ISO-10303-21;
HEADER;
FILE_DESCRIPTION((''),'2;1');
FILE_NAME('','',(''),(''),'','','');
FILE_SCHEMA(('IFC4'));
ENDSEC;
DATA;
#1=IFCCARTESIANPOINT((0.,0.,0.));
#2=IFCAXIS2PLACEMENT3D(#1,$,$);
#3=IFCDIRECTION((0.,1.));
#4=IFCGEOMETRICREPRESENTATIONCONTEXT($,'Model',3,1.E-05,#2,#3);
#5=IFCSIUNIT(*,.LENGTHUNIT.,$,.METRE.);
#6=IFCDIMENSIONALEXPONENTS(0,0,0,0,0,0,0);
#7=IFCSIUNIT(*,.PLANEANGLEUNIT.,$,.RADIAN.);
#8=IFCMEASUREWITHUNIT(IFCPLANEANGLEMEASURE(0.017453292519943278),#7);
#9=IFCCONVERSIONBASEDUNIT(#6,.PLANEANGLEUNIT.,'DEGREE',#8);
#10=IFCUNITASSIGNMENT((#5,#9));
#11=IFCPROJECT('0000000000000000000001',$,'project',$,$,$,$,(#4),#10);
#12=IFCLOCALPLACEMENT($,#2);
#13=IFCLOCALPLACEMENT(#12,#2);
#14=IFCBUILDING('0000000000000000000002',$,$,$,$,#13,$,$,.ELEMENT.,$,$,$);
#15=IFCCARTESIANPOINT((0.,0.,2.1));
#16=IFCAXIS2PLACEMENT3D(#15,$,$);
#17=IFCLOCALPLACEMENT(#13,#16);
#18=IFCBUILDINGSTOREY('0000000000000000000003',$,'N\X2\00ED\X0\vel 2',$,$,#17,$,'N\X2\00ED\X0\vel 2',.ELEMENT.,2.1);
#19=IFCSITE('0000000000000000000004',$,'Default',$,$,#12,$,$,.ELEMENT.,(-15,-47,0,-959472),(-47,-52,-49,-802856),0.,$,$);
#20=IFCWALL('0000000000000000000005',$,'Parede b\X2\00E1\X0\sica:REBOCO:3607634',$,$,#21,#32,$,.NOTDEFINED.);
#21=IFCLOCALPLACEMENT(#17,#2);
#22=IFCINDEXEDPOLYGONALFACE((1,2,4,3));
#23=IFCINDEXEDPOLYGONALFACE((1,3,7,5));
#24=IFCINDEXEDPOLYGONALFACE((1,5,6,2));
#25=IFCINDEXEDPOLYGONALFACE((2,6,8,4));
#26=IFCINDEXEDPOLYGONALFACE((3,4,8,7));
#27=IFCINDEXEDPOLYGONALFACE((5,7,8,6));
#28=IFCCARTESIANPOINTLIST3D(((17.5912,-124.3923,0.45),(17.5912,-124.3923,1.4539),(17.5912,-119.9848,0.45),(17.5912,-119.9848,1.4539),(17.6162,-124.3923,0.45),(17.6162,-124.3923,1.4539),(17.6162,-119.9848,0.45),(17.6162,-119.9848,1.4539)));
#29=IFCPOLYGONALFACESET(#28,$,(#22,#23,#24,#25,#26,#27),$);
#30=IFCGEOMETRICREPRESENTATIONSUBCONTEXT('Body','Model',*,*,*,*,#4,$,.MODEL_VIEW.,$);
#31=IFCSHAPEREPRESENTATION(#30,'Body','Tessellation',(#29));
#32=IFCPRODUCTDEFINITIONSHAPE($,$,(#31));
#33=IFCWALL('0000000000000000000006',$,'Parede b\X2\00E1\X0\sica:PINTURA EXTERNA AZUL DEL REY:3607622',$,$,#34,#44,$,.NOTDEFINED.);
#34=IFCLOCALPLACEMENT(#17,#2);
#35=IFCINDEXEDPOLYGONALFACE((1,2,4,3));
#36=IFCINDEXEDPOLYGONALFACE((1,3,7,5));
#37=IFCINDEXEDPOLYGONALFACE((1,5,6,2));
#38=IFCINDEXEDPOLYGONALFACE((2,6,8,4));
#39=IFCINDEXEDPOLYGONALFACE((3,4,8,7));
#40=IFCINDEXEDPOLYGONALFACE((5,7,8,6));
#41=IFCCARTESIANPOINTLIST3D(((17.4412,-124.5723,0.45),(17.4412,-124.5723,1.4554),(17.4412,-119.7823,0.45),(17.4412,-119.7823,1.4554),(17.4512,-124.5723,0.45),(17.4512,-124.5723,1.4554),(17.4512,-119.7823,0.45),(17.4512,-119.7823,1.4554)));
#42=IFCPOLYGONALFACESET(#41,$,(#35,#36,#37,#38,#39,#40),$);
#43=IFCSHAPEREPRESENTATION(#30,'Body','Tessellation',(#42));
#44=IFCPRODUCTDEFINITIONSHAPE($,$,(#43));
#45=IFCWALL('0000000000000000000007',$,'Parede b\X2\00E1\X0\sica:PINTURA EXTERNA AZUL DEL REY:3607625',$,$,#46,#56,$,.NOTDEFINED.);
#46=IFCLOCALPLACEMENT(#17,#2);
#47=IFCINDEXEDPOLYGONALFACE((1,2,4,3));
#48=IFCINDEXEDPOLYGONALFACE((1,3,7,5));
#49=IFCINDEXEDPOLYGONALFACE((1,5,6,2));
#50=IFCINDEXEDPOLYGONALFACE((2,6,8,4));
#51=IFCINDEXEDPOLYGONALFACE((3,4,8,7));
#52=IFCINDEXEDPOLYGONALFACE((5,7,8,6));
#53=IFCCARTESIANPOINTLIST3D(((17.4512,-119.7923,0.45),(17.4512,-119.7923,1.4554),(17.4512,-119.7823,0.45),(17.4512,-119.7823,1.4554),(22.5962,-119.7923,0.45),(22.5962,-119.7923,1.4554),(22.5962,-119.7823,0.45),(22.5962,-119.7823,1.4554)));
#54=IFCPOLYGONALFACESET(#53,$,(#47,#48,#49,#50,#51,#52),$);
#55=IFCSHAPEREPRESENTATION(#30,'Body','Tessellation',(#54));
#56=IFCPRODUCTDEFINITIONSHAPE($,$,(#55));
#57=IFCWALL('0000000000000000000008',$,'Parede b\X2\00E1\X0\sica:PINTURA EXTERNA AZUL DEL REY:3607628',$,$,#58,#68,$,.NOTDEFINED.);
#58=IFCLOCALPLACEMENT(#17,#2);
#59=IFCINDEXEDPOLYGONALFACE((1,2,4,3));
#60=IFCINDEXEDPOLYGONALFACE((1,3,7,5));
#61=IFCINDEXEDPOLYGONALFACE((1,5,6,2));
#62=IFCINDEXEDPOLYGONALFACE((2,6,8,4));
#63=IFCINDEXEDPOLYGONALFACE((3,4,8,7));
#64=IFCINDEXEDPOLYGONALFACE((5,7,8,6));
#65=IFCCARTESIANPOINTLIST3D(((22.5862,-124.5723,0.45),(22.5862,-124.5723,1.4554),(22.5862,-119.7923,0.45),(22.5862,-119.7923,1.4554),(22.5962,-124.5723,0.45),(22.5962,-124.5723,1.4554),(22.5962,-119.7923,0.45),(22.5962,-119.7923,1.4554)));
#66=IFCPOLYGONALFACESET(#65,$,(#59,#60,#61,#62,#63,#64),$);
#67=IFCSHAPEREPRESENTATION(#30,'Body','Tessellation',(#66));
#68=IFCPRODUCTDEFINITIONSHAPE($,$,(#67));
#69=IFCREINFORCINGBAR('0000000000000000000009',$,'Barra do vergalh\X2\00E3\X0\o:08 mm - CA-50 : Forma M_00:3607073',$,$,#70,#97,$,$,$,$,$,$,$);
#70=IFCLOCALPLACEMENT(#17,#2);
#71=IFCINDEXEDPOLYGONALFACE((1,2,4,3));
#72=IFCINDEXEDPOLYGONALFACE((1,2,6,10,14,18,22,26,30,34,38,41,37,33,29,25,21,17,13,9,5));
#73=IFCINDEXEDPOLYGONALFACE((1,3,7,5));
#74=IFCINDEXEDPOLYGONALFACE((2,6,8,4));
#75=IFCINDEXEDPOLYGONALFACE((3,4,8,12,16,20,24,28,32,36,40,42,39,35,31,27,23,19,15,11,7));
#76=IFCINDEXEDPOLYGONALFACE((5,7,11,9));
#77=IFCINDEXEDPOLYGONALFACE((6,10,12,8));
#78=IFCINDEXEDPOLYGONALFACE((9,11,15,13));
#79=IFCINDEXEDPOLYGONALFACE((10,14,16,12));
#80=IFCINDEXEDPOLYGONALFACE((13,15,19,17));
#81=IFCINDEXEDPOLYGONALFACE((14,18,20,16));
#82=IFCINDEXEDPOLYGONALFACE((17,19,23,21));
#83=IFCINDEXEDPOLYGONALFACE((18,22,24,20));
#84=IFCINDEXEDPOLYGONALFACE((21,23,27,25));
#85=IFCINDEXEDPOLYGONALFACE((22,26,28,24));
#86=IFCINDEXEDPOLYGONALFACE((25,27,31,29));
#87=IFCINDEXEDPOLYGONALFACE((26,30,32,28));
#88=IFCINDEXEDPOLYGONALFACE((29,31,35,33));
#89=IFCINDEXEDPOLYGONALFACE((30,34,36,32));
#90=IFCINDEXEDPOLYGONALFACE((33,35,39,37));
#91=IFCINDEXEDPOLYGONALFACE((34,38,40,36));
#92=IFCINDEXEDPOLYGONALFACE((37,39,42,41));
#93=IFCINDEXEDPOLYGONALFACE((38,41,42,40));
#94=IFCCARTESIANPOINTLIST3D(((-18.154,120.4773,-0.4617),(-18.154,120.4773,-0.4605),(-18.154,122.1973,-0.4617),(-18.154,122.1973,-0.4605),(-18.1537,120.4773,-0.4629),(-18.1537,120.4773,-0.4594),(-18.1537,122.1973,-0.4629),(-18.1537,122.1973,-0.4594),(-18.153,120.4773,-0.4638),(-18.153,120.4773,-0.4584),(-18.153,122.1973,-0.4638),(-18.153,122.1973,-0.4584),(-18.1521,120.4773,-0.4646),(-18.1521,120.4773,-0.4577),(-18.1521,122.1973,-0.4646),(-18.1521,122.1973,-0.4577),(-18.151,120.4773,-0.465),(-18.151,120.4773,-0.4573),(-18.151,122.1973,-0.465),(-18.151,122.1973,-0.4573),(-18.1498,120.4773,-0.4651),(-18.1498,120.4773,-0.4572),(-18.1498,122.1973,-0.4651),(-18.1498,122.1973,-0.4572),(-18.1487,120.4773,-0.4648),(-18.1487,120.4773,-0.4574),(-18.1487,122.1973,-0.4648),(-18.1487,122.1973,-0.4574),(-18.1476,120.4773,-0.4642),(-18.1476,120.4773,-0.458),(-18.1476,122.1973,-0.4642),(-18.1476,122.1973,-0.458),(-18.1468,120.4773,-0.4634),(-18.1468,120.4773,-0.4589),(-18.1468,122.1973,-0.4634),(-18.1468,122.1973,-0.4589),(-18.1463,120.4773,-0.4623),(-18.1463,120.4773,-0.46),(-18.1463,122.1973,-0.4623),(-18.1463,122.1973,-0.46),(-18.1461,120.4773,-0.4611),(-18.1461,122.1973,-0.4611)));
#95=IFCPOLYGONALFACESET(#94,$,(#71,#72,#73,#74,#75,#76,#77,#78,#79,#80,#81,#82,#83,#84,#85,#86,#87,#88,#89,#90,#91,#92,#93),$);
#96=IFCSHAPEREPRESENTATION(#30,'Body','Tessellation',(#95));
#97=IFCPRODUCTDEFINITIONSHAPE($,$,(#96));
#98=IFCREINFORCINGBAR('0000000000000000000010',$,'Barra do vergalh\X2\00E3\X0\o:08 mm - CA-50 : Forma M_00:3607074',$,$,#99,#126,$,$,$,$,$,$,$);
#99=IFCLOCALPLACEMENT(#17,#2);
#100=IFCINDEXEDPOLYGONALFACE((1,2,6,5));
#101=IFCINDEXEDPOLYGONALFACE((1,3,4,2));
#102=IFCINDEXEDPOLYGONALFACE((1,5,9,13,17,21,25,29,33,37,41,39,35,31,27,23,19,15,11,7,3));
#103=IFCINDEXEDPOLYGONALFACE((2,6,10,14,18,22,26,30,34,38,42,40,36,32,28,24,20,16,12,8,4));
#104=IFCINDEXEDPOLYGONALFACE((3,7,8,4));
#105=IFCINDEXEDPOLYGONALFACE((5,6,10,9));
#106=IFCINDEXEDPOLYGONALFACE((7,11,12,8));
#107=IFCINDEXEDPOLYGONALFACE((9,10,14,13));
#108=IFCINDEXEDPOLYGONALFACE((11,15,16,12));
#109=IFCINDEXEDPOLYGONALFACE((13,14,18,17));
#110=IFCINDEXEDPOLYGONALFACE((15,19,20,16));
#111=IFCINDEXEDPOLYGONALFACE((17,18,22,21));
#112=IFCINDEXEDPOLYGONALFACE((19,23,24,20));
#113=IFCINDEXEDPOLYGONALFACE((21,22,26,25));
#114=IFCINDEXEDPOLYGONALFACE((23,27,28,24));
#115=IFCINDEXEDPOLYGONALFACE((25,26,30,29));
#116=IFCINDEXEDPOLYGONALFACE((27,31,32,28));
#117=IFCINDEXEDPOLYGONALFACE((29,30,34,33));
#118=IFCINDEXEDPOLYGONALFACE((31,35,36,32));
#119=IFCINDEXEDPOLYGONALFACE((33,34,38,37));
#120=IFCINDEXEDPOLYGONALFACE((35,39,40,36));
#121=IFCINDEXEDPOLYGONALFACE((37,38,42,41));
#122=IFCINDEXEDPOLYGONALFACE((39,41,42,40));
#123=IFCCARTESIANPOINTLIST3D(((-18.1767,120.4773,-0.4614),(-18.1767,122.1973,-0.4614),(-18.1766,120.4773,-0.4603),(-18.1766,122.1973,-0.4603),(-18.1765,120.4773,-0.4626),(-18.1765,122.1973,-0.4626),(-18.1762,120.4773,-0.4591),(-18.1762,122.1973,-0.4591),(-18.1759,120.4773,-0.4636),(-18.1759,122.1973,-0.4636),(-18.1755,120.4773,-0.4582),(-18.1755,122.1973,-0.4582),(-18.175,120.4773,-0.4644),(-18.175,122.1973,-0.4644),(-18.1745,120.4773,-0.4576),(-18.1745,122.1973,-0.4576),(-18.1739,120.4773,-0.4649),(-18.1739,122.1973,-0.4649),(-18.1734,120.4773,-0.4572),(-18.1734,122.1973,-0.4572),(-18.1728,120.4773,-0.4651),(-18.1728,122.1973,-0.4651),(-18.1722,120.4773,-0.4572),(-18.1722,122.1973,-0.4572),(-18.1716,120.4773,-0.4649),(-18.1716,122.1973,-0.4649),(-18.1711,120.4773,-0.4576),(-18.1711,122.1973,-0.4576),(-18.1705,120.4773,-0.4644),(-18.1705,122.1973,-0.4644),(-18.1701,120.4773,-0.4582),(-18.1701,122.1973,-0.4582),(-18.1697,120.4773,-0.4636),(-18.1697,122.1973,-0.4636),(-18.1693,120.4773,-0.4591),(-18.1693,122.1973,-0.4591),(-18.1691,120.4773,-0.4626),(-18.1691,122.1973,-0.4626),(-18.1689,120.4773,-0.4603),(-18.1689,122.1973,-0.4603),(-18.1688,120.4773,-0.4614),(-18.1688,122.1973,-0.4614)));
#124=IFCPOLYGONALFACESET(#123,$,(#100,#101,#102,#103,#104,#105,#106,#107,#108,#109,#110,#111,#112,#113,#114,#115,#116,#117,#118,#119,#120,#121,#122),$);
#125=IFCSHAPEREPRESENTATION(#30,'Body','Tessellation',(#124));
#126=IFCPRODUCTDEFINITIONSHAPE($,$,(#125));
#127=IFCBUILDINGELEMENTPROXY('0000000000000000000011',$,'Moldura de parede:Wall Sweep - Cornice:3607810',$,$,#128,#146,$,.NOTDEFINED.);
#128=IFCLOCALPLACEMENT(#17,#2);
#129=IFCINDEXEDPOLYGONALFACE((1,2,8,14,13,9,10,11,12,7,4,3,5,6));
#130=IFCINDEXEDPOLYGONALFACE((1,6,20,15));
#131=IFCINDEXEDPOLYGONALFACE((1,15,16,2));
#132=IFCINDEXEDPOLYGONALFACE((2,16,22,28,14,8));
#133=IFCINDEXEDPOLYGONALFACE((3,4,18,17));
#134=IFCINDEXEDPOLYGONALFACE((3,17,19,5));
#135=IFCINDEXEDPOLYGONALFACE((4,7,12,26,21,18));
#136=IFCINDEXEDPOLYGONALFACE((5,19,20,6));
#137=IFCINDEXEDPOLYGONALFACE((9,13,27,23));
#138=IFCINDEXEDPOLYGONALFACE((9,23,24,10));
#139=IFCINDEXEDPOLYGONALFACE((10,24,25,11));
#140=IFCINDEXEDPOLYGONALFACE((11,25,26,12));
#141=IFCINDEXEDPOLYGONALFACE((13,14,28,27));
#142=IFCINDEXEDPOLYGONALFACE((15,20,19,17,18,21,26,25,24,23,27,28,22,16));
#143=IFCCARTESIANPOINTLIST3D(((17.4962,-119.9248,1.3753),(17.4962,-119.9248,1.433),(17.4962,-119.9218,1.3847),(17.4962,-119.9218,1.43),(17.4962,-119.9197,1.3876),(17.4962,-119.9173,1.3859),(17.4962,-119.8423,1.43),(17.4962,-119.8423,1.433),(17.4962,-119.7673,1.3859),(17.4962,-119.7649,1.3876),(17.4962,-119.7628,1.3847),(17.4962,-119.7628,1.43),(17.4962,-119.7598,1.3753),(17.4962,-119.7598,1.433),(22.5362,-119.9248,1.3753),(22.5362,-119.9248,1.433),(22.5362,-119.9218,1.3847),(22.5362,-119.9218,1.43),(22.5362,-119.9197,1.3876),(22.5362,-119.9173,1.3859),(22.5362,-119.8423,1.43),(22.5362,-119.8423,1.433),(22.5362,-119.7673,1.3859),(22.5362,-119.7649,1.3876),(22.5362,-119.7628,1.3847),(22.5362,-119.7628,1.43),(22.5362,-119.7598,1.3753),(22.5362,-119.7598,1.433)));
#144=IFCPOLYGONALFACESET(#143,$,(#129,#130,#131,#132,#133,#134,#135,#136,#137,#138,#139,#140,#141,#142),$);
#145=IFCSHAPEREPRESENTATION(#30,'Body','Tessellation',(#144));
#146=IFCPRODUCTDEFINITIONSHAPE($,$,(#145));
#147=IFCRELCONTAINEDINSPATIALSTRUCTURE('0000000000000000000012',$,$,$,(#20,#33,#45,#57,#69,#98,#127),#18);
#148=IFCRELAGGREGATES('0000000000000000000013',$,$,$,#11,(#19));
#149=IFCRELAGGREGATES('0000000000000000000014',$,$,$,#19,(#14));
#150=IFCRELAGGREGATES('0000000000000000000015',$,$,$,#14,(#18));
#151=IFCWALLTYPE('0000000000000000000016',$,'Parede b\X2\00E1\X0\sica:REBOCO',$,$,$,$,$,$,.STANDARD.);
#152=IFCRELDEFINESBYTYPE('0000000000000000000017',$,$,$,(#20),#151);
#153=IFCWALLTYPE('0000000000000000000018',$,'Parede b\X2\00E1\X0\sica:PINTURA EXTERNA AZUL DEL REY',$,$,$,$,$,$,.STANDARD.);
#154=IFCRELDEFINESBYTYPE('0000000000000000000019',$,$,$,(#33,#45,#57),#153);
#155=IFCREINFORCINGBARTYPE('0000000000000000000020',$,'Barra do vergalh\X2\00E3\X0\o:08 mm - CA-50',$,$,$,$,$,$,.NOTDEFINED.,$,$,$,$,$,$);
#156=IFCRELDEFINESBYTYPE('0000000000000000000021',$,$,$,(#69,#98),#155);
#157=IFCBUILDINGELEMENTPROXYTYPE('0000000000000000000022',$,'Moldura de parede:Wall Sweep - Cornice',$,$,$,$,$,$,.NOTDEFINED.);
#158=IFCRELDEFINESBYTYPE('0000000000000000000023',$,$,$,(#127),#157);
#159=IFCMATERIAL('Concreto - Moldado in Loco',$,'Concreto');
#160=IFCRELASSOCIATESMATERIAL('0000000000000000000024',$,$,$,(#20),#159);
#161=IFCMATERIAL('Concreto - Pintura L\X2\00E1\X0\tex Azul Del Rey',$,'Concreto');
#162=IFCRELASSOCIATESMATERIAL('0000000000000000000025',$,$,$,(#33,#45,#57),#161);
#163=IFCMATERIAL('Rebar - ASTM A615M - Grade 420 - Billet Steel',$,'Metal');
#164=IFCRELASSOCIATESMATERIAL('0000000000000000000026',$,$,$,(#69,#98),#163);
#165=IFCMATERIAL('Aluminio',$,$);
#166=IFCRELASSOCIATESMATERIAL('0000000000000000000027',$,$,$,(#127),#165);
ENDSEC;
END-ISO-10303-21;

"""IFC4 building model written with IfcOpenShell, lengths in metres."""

from ifc_helpers import new_model, entity, si_unit, converted_unit, direction, frame, origin, place, context, subcontext, project, spatial, indexed_curve, outline, extrude, material, type_object, element, save


model = new_model("IFC4")

# Units and contexts
model_context = context("Model", 3, precision=1e-05, world=origin(), true_north=direction((0.0, 1.0)))
body_context = subcontext(model_context, "Body", "Model", "MODEL_VIEW")
ifc_project = project(units=[si_unit("LENGTHUNIT", "METRE"), converted_unit("PLANEANGLEUNIT", "DEGREE", entity("IfcPlaneAngleMeasure", 0.017453292519943278), si_unit("PLANEANGLEUNIT", "RADIAN"), dimensions=[0, 0, 0, 0, 0, 0, 0])], contexts=[model_context])

# Site, building, storey
site_placement = place(None, origin())
site = spatial("IfcSite", under=ifc_project, at=site_placement, Name="Default", CompositionType="ELEMENT", RefLatitude=(-15, -47, 0, -959472), RefLongitude=(-47, -52, -49, -802856), RefElevation=0.0)
building_placement = place(site_placement, origin())
building = spatial("IfcBuilding", under=site, at=building_placement, CompositionType="ELEMENT")
storey_placement = place(building_placement, frame((0.0, 0.0, 2.1)))
storey = spatial("IfcBuildingStorey", under=building, at=storey_placement, Name="Nível 2", LongName="Nível 2", CompositionType="ELEMENT", Elevation=2.1)

# Shared definitions
ifc_material_1 = material(Name="Concreto - Moldado in Loco", Category="Concreto")

# Walls
wall_type_1 = type_object("IfcWallType", Name="Parede básica:REBOCO", PredefinedType="STANDARD")
wall_1_placement = place(storey_placement, frame((17.6037, -119.9848, 0.45), z_axis=(0.0, 0.0, 1.0), x_axis=(0.0, -1.0, 0.0)))
element("IfcWall", 1, at=wall_1_placement, inside=storey, type_object=wall_type_1, material=ifc_material_1, Name="Parede básica:REBOCO:3607634", PredefinedType="NOTDEFINED", context=body_context, shape_type="SweptSolid", body=[
    extrude(outline(indexed_curve([(4.4075, 0.0125), (0.0, 0.0125), (0.0, -0.0125), (4.4075, -0.0125), (4.4075, 0.0125)], self_intersect=False)), origin(), (0.0, 0.0, 1.0), 1.0039),
])
ifc_material_2 = material(Name="Concreto - Pintura Látex Azul Del Rey", Category="Concreto")
wall_type_2 = type_object("IfcWallType", Name="Parede básica:PINTURA EXTERNA AZUL DEL REY", PredefinedType="STANDARD")
wall_2_placement = place(storey_placement, frame((17.4462, -119.7823, 0.45), z_axis=(0.0, 0.0, 1.0), x_axis=(0.0, -1.0, 0.0)))
element("IfcWall", 2, at=wall_2_placement, inside=storey, type_object=wall_type_2, material=ifc_material_2, Name="Parede básica:PINTURA EXTERNA AZUL DEL REY:3607622", PredefinedType="NOTDEFINED", context=body_context, shape_type="SweptSolid", body=[
    extrude(outline(indexed_curve([(4.79, 0.005), (0.0, 0.005), (0.0, -0.005), (4.79, -0.005), (4.79, 0.005)], self_intersect=False)), origin(), (0.0, 0.0, 1.0), 1.0054),
])
wall_3_placement = place(storey_placement, frame((17.4512, -119.7873, 0.45)))
element("IfcWall", 3, at=wall_3_placement, inside=storey, type_object=wall_type_2, material=ifc_material_2, Name="Parede básica:PINTURA EXTERNA AZUL DEL REY:3607625", PredefinedType="NOTDEFINED", context=body_context, shape_type="SweptSolid", body=[
    extrude(outline(indexed_curve([(5.145, 0.005), (0.0, 0.005), (0.0, -0.005), (5.145, -0.005), (5.145, 0.005)], self_intersect=False)), origin(), (0.0, 0.0, 1.0), 1.0054),
])
wall_4_placement = place(storey_placement, frame((22.5912, -119.7923, 0.45), z_axis=(0.0, 0.0, 1.0), x_axis=(0.0, -1.0, 0.0)))
element("IfcWall", 4, at=wall_4_placement, inside=storey, type_object=wall_type_2, material=ifc_material_2, Name="Parede básica:PINTURA EXTERNA AZUL DEL REY:3607628", PredefinedType="NOTDEFINED", context=body_context, shape_type="SweptSolid", body=[
    extrude(outline(indexed_curve([(4.78, 0.005), (0.0, 0.005), (0.0, -0.005), (4.78, -0.005), (4.78, 0.005)], self_intersect=False)), origin(), (0.0, 0.0, 1.0), 1.0054),
])

# Reinforcing bars
ifc_material_3 = material(Name="Rebar - ASTM A615M - Grade 420 - Billet Steel", Category="Metal")
reinforcing_bar_type = type_object("IfcReinforcingBarType", Name="Barra do vergalhão:08 mm - CA-50", PredefinedType="NOTDEFINED")
reinforcing_bar_1_placement = place(storey_placement, origin())
element("IfcReinforcingBar", 5, at=reinforcing_bar_1_placement, inside=storey, type_object=reinforcing_bar_type, material=ifc_material_3, Name="Barra do vergalhão:08 mm - CA-50 : Forma M_00:3607073", context=body_context, shape_type="AdvancedSweptSolid", body=[
    entity("IfcSweptDiskSolid", entity("IfcIndexedPolyCurve", entity("IfcCartesianPointList3D", [[18.1501, -122.1973, 0.4611], [18.1501, -120.4773, 0.4611]]), None, False), 0.004, None, 0.0, 1.0),
])
reinforcing_bar_2_placement = place(storey_placement, origin())
element("IfcReinforcingBar", 6, at=reinforcing_bar_2_placement, inside=storey, type_object=reinforcing_bar_type, material=ifc_material_3, Name="Barra do vergalhão:08 mm - CA-50 : Forma M_00:3607074", context=body_context, shape_type="AdvancedSweptSolid", body=[
    entity("IfcSweptDiskSolid", entity("IfcIndexedPolyCurve", entity("IfcCartesianPointList3D", [[18.1728, -120.4773, 0.4611], [18.1728, -122.1973, 0.4611]]), None, False), 0.004, None, 0.0, 1.0),
])

# Building element proxy
ifc_material_4 = material(Name="Aluminio")
building_element_proxy_type_1 = type_object("IfcBuildingElementProxyType", Name="Moldura de parede:Wall Sweep - Cornice", PredefinedType="NOTDEFINED")
proxy_placement = place(storey_placement, frame((17.4962, -119.9248, 1.3753)))
element("IfcBuildingElementProxy", 7, at=proxy_placement, inside=storey, type_object=building_element_proxy_type_1, material=ifc_material_4, Name="Moldura de parede:Wall Sweep - Cornice:3607810", PredefinedType="NOTDEFINED", context=body_context, shape_type="SweptSolid", body=[
    extrude(outline(indexed_curve([(-0.0825, -0.029), (0.0, -0.029), (0.0825, -0.029), (0.0825, 0.0287), (0.075, 0.0181), (0.0774, 0.0164), (0.0795, 0.0193), (0.0795, -0.026), (0.0, -0.026), (-0.0795, -0.026), (-0.0795, 0.0193), (-0.0774, 0.0164), (-0.075, 0.0181), (-0.0825, 0.0287), (-0.0825, -0.029)], self_intersect=False)), frame((0.0, 0.0825, 0.0287), z_axis=(1.0, 0.0, 0.0), x_axis=(0.0, -1.0, 0.0)), (0.0, 0.0, 1.0), 5.04),
])

save(model, "model.ifc")
